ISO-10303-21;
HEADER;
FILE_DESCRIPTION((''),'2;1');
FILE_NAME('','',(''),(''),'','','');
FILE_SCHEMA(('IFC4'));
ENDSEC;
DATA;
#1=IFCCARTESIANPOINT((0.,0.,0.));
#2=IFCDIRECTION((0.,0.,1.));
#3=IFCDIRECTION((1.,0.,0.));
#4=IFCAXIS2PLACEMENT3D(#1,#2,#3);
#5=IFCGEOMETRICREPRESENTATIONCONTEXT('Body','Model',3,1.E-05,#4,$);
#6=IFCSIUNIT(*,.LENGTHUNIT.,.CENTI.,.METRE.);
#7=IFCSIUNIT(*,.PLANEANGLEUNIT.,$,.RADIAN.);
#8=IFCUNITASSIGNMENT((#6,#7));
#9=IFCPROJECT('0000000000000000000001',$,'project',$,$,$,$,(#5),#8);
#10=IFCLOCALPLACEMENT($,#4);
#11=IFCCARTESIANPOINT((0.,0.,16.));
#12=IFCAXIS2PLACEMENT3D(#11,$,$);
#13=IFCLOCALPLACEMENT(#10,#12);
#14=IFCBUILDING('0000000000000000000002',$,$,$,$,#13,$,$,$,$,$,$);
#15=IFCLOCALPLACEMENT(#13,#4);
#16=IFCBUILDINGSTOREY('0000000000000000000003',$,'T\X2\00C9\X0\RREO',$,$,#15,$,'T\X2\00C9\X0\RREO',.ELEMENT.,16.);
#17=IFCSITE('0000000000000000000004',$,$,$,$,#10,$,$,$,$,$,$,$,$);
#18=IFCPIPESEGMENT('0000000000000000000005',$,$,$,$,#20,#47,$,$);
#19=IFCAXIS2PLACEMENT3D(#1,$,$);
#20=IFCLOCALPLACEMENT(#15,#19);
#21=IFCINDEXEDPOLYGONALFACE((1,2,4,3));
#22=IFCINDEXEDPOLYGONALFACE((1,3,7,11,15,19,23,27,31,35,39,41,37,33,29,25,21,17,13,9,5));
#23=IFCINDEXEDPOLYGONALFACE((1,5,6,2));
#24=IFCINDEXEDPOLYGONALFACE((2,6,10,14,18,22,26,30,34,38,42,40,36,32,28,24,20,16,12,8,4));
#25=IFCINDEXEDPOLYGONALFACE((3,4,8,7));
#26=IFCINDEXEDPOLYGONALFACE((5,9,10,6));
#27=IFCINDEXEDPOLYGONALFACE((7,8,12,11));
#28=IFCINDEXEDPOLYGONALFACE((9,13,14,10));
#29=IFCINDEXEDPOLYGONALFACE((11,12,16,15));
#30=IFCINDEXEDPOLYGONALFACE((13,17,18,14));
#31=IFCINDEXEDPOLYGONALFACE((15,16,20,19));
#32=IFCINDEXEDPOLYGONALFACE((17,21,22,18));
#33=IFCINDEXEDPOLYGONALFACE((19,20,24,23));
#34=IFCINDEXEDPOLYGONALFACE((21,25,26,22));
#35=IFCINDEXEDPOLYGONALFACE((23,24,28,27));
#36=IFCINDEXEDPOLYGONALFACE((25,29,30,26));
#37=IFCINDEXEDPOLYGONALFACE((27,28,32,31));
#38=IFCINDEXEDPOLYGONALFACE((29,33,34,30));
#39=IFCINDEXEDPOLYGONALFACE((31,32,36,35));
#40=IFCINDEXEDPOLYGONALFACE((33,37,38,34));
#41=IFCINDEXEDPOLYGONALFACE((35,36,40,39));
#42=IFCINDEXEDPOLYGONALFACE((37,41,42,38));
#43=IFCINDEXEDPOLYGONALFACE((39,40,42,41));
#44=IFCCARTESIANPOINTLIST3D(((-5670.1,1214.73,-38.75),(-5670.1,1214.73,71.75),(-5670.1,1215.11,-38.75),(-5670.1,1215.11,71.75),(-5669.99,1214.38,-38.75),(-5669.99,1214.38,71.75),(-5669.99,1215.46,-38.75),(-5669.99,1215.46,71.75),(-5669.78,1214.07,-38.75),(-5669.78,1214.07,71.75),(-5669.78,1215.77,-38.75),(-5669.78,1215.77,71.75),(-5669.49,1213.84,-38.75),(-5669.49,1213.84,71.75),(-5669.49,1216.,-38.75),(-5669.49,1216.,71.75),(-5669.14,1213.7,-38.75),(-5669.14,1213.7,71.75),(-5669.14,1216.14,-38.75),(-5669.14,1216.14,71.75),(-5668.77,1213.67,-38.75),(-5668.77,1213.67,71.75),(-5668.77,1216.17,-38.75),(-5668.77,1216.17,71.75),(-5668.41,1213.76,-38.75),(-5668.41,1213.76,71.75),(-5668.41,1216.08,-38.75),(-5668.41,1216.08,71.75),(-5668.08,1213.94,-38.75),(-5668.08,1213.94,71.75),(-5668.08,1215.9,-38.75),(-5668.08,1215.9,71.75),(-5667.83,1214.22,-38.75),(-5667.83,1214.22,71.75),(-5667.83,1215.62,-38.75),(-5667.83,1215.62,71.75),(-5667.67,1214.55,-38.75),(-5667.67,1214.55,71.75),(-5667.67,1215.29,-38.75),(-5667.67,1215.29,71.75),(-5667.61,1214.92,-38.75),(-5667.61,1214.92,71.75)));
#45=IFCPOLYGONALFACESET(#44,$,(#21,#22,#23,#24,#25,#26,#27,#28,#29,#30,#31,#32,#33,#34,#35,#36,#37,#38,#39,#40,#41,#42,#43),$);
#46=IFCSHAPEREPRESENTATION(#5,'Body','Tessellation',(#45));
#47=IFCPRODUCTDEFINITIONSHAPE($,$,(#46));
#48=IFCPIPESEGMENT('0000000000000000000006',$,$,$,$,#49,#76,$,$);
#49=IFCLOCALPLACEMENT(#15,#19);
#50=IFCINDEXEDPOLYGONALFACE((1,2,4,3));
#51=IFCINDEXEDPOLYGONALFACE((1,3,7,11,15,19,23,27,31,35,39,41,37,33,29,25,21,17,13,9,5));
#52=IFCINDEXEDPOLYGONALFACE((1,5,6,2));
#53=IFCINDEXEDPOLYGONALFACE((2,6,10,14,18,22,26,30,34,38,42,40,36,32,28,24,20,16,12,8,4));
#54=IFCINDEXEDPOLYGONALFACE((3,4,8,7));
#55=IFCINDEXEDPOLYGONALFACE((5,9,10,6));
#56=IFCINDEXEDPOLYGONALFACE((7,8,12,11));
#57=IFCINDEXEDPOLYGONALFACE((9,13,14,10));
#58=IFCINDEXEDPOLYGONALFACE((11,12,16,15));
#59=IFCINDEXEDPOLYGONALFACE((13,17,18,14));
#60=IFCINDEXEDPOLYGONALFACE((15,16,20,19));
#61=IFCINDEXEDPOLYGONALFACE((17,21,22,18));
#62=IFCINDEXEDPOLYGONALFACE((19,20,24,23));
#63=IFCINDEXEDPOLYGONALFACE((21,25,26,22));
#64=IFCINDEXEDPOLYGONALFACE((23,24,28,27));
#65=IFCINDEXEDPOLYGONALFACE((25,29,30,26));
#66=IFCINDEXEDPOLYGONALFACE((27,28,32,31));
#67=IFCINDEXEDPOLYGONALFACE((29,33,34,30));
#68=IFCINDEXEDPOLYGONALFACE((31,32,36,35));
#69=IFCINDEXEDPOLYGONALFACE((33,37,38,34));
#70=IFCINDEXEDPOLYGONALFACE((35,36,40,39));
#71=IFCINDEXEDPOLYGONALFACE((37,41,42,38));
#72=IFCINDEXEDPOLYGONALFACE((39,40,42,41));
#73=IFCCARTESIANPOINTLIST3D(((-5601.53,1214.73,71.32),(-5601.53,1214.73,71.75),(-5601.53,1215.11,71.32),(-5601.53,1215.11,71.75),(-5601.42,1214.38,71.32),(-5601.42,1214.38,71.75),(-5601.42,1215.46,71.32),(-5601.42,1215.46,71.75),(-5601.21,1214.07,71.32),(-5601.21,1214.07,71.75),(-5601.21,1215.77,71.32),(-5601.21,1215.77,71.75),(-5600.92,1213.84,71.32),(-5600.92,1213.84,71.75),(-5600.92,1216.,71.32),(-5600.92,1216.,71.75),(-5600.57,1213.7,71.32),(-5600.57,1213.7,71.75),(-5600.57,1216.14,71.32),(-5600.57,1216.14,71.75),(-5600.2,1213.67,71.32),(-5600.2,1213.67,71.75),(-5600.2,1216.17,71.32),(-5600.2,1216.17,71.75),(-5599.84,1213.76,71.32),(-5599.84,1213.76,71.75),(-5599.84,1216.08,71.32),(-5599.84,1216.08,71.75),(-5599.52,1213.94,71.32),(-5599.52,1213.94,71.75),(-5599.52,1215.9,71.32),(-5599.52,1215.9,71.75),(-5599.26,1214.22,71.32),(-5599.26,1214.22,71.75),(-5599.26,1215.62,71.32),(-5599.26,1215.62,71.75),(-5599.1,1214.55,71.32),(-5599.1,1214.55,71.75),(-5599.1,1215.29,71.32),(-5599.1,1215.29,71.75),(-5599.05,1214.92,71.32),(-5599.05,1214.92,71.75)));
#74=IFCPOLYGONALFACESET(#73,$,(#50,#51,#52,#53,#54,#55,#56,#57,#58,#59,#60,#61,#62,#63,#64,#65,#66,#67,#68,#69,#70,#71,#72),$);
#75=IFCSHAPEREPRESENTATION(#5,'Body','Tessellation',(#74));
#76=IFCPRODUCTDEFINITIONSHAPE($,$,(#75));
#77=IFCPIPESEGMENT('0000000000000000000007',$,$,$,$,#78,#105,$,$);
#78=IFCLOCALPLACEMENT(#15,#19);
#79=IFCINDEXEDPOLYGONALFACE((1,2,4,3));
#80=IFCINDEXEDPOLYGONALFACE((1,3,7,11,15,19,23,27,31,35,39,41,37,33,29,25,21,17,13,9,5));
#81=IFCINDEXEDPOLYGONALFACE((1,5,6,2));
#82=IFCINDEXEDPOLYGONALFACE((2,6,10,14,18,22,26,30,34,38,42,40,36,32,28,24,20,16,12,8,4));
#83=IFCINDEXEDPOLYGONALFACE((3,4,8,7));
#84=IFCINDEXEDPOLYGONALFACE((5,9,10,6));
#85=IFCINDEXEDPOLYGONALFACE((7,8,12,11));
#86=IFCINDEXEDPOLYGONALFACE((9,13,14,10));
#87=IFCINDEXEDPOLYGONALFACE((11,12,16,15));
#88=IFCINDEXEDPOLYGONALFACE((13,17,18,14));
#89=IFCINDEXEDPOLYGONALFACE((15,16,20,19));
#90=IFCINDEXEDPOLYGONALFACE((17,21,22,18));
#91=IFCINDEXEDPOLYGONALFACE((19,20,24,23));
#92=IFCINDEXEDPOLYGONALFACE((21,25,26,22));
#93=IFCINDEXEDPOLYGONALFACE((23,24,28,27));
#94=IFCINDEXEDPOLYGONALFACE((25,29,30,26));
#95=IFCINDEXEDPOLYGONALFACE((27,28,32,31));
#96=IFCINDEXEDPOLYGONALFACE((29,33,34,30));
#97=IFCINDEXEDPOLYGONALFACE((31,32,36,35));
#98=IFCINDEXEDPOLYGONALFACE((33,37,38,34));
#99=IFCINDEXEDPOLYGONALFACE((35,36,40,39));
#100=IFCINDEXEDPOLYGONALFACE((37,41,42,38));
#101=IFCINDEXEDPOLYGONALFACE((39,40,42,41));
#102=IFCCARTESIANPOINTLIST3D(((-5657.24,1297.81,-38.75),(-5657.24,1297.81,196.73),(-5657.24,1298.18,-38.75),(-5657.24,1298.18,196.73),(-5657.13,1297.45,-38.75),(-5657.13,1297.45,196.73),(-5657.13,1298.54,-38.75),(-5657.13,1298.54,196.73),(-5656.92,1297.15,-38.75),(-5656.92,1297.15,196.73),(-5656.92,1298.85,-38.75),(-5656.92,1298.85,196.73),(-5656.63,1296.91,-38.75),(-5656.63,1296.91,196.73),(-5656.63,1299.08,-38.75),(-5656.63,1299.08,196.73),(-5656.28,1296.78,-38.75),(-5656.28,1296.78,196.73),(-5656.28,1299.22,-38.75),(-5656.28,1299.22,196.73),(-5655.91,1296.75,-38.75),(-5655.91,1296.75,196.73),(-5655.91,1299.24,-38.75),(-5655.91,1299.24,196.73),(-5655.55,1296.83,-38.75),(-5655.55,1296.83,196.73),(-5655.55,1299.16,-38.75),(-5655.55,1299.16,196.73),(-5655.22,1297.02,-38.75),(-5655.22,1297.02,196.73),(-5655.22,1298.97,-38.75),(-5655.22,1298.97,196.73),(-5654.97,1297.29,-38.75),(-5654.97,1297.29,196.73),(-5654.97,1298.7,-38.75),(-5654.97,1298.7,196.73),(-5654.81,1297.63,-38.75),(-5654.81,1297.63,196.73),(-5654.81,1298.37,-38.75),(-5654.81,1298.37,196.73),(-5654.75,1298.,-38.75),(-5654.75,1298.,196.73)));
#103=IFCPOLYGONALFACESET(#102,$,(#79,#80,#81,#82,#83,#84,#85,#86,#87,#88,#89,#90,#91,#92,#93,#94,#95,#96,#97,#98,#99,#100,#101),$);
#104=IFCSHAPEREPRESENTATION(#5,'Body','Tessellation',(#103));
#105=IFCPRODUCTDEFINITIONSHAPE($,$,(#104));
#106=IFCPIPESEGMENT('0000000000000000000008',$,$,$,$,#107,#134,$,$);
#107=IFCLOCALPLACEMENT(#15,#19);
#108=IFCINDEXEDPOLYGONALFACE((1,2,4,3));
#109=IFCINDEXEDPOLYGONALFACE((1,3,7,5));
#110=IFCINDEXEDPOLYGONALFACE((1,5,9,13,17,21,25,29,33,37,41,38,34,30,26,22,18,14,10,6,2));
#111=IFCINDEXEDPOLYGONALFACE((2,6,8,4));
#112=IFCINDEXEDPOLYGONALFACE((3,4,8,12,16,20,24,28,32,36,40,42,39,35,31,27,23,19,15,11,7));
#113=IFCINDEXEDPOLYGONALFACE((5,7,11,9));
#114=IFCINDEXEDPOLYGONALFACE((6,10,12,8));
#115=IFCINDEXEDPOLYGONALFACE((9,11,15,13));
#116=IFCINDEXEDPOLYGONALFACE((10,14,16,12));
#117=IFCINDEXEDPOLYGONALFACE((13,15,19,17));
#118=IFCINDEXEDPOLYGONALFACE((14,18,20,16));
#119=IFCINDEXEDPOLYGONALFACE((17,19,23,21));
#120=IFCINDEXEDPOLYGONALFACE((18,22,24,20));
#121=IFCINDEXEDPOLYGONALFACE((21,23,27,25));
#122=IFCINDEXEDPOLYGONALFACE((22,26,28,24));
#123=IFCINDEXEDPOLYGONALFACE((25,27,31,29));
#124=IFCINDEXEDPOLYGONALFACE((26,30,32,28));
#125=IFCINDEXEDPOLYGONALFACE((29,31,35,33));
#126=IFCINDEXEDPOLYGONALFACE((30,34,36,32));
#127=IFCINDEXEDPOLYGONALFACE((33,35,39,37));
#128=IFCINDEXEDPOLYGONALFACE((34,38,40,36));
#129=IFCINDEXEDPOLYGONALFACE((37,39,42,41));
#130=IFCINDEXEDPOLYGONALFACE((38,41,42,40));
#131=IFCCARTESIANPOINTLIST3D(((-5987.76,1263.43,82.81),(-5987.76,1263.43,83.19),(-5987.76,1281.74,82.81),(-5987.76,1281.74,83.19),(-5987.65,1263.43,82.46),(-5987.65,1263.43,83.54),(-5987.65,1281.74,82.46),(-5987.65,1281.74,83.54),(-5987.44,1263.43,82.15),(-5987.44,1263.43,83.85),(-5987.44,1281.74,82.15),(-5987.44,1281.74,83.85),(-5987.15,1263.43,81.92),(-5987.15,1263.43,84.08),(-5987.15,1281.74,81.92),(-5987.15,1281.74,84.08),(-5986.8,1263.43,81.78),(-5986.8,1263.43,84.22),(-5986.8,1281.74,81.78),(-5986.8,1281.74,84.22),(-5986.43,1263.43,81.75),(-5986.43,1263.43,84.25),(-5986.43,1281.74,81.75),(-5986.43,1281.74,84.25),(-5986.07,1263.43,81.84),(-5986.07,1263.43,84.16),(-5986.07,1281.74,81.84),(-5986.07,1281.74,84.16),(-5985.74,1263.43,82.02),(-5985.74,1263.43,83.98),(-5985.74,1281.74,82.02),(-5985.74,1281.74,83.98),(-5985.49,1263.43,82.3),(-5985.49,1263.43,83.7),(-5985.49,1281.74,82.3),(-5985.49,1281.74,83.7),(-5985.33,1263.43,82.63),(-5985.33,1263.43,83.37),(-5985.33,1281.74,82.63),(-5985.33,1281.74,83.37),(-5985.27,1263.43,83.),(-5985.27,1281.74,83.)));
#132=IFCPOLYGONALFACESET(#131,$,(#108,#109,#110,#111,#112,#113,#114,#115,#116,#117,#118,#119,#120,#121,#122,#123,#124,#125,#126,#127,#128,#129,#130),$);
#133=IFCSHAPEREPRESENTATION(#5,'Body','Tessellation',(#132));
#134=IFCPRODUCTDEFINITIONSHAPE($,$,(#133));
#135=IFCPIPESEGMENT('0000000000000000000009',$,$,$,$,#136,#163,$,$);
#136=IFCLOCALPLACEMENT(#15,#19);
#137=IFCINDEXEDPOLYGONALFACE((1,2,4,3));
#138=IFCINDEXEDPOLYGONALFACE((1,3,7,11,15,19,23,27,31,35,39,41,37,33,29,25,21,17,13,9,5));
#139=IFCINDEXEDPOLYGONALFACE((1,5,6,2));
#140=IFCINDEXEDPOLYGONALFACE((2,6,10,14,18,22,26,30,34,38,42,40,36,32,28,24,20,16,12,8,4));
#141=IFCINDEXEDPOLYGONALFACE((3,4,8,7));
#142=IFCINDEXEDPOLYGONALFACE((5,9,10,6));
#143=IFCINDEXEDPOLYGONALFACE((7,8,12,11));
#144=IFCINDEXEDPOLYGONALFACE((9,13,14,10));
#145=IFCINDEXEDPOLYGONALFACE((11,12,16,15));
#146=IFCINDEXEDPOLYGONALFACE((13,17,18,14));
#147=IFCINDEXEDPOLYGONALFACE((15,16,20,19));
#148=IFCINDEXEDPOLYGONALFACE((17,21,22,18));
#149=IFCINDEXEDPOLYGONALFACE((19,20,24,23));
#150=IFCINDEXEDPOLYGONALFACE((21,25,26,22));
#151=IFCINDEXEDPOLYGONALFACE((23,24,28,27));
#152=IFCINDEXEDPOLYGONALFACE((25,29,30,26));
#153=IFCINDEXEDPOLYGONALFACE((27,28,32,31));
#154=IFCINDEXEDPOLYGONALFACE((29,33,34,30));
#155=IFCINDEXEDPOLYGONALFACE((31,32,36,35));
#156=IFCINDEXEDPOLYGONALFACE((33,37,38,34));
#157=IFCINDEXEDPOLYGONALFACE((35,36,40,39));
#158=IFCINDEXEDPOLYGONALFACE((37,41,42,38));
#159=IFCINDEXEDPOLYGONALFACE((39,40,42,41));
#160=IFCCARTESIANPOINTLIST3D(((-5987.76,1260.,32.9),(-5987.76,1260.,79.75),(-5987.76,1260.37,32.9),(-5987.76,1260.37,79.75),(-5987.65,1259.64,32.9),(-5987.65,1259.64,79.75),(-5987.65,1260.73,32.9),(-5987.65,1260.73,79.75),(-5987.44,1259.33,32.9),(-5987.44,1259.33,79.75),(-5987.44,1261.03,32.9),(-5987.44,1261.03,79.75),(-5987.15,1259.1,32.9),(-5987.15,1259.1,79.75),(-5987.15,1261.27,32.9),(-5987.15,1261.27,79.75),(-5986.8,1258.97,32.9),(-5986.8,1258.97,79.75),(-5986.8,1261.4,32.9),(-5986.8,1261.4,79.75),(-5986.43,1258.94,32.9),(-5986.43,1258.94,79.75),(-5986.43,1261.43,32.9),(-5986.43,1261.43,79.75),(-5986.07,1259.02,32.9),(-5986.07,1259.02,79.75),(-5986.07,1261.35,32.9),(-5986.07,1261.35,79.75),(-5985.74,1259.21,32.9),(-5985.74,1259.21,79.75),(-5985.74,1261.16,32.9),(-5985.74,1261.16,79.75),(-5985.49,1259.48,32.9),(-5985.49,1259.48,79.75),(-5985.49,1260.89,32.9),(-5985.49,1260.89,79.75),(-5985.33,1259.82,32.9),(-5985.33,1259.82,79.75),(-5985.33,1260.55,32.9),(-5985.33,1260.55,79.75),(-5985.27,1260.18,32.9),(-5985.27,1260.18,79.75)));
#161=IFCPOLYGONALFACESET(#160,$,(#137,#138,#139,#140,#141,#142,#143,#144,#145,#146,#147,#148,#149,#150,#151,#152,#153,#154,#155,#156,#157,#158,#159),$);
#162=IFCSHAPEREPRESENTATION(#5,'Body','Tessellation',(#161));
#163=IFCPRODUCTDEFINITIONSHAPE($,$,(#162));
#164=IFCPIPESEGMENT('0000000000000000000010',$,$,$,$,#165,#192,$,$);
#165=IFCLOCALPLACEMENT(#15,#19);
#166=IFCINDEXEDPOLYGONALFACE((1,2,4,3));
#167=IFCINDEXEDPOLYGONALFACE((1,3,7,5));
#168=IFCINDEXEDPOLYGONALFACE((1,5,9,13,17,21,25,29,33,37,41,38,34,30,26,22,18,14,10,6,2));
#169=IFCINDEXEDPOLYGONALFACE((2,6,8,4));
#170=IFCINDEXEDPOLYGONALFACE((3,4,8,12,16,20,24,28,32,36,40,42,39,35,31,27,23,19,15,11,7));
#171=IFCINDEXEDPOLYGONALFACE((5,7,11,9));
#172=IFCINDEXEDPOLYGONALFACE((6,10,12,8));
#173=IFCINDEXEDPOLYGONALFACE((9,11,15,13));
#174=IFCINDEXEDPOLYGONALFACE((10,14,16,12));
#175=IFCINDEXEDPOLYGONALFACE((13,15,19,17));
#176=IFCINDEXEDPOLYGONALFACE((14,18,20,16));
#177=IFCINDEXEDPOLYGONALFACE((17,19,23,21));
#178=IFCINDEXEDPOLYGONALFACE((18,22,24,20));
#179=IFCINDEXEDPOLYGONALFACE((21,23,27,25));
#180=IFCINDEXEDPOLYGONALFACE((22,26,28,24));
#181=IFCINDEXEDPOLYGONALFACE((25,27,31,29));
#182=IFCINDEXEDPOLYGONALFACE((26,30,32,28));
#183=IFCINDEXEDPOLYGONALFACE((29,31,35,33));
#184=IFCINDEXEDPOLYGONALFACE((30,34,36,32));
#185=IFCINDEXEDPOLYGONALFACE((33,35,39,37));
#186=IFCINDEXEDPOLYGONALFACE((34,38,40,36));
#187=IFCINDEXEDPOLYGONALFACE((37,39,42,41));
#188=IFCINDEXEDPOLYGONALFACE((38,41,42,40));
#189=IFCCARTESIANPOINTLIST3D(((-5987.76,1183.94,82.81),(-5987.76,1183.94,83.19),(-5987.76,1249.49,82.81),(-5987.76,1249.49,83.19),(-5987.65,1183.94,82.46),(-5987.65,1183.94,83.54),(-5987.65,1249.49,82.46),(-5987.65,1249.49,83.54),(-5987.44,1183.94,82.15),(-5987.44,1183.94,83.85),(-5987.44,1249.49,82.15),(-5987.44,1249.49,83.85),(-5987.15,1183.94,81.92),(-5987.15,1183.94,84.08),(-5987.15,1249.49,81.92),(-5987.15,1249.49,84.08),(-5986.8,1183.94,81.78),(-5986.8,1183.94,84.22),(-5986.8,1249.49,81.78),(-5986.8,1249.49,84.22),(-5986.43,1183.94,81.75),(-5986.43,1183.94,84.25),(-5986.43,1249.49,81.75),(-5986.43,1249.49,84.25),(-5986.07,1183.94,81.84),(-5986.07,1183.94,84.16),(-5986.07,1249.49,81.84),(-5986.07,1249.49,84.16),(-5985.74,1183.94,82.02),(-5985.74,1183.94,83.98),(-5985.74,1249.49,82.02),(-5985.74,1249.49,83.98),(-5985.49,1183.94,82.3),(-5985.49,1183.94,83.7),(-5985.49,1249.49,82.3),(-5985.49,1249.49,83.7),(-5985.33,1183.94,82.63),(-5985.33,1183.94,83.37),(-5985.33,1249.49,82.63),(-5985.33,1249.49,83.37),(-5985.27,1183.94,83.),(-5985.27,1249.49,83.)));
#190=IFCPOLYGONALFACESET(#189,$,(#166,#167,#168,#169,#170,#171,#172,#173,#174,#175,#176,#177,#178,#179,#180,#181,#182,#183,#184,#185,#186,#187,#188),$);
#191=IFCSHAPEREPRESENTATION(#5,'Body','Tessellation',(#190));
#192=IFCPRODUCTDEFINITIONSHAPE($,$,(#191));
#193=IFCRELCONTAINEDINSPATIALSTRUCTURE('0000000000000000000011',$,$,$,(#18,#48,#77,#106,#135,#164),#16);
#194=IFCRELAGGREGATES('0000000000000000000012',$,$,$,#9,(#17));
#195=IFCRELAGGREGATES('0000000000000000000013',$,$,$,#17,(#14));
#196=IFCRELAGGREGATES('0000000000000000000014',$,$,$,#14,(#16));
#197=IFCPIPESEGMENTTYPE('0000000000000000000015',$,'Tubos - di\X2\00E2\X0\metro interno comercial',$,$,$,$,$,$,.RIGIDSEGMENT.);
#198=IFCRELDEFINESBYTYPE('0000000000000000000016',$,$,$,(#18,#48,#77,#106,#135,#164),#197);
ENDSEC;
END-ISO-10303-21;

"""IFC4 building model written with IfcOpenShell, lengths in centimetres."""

from ifc_helpers import new_model, si_unit, frame, origin_with_axes, origin_2d_with_axis, place, context, project, spatial, circle, extrude, type_object, element, save


model = new_model("IFC4")

# Units and contexts
model_context = context("Model", 3, precision=1e-05, world=origin_with_axes(), identifier="Body")
ifc_project = project(units=[si_unit("LENGTHUNIT", "METRE", prefix="CENTI"), si_unit("PLANEANGLEUNIT", "RADIAN")], contexts=[model_context])

# Site, building, storey
site_placement = place(None, origin_with_axes())
site = spatial("IfcSite", under=ifc_project, at=site_placement)
building_placement = place(site_placement, frame((0.0, 0.0, 16.0)))
building = spatial("IfcBuilding", under=site, at=building_placement)
storey_placement = place(building_placement, origin_with_axes())
storey = spatial("IfcBuildingStorey", under=building, at=storey_placement, Name="TÉRREO", LongName="TÉRREO", CompositionType="ELEMENT", Elevation=16.0)

# Pipe segments
pipe_segment_type = type_object("IfcPipeSegmentType", Name="Tubos - diâmetro interno comercial", PredefinedType="RIGIDSEGMENT")
pipe_segment_1_placement = place(storey_placement, frame((-5668.86, 1214.92, 71.75), z_axis=(0.0, 0.0, 1.0), x_axis=(1.0, 0.0, 0.0)))
element("IfcPipeSegment", 1, at=pipe_segment_1_placement, inside=storey, type_object=pipe_segment_type, context=model_context, shape_type="SolidModel", body=[
    extrude(circle(Radius=1.25, at=origin_2d_with_axis()), frame((0.0, 0.0, -110.5), z_axis=(0.0, 0.0, 1.0), x_axis=(1.0, 0.0, 0.0)), (0.0, 0.0, 1.0), 110.5),
])
pipe_segment_2_placement = place(storey_placement, frame((-5600.3, 1214.92, 71.75), z_axis=(0.0, 0.0, 1.0), x_axis=(1.0, 0.0, 0.0)))
element("IfcPipeSegment", 2, at=pipe_segment_2_placement, inside=storey, type_object=pipe_segment_type, context=model_context, shape_type="SolidModel", body=[
    extrude(circle(Radius=1.25, at=origin_2d_with_axis()), frame((0.0, 0.0, 0.0), z_axis=(0.0, 0.0, -1.0), x_axis=(1.0, 0.0, 0.0)), (0.0, 0.0, 1.0), 0.43),
])
pipe_segment_3_placement = place(storey_placement, frame((-5656.0, 1298.0, 196.73), z_axis=(0.0, 0.0, 1.0), x_axis=(1.0, 0.0, 0.0)))
element("IfcPipeSegment", 3, at=pipe_segment_3_placement, inside=storey, type_object=pipe_segment_type, context=model_context, shape_type="SolidModel", body=[
    extrude(circle(Radius=1.25, at=origin_2d_with_axis()), frame((0.0, 0.0, -235.48), z_axis=(0.0, 0.0, 1.0), x_axis=(1.0, 0.0, 0.0)), (0.0, 0.0, 1.0), 235.48),
])
pipe_segment_4_placement = place(storey_placement, frame((-5986.52, 1272.59, 84.25), z_axis=(0.0, 0.0, 1.0), x_axis=(1.0, 0.0, 0.0)))
element("IfcPipeSegment", 4, at=pipe_segment_4_placement, inside=storey, type_object=pipe_segment_type, context=model_context, shape_type="SolidModel", body=[
    extrude(circle(Radius=1.25, at=origin_2d_with_axis()), frame((0.0, 9.15, -1.25), z_axis=(0.0, -1.0, 0.0), x_axis=(1.0, 0.0, 0.0)), (0.0, 0.0, 1.0), 18.31),
])
pipe_segment_5_placement = place(storey_placement, frame((-5986.52, 1260.18, 79.75), z_axis=(0.0, 0.0, 1.0), x_axis=(1.0, 0.0, 0.0)))
element("IfcPipeSegment", 5, at=pipe_segment_5_placement, inside=storey, type_object=pipe_segment_type, context=model_context, shape_type="SolidModel", body=[
    extrude(circle(Radius=1.25, at=origin_2d_with_axis()), frame((0.0, 0.0, 0.0), z_axis=(0.0, 0.0, -1.0), x_axis=(1.0, 0.0, 0.0)), (0.0, 0.0, 1.0), 46.85),
])
pipe_segment_6_placement = place(storey_placement, frame((-5986.52, 1216.72, 84.25), z_axis=(0.0, 0.0, 1.0), x_axis=(1.0, 0.0, 0.0)))
element("IfcPipeSegment", 6, at=pipe_segment_6_placement, inside=storey, type_object=pipe_segment_type, context=model_context, shape_type="SolidModel", body=[
    extrude(circle(Radius=1.25, at=origin_2d_with_axis()), frame((0.0, 32.78, -1.25), z_axis=(0.0, -1.0, 0.0), x_axis=(1.0, 0.0, 0.0)), (0.0, 0.0, 1.0), 65.55),
])

save(model, "model.ifc")
